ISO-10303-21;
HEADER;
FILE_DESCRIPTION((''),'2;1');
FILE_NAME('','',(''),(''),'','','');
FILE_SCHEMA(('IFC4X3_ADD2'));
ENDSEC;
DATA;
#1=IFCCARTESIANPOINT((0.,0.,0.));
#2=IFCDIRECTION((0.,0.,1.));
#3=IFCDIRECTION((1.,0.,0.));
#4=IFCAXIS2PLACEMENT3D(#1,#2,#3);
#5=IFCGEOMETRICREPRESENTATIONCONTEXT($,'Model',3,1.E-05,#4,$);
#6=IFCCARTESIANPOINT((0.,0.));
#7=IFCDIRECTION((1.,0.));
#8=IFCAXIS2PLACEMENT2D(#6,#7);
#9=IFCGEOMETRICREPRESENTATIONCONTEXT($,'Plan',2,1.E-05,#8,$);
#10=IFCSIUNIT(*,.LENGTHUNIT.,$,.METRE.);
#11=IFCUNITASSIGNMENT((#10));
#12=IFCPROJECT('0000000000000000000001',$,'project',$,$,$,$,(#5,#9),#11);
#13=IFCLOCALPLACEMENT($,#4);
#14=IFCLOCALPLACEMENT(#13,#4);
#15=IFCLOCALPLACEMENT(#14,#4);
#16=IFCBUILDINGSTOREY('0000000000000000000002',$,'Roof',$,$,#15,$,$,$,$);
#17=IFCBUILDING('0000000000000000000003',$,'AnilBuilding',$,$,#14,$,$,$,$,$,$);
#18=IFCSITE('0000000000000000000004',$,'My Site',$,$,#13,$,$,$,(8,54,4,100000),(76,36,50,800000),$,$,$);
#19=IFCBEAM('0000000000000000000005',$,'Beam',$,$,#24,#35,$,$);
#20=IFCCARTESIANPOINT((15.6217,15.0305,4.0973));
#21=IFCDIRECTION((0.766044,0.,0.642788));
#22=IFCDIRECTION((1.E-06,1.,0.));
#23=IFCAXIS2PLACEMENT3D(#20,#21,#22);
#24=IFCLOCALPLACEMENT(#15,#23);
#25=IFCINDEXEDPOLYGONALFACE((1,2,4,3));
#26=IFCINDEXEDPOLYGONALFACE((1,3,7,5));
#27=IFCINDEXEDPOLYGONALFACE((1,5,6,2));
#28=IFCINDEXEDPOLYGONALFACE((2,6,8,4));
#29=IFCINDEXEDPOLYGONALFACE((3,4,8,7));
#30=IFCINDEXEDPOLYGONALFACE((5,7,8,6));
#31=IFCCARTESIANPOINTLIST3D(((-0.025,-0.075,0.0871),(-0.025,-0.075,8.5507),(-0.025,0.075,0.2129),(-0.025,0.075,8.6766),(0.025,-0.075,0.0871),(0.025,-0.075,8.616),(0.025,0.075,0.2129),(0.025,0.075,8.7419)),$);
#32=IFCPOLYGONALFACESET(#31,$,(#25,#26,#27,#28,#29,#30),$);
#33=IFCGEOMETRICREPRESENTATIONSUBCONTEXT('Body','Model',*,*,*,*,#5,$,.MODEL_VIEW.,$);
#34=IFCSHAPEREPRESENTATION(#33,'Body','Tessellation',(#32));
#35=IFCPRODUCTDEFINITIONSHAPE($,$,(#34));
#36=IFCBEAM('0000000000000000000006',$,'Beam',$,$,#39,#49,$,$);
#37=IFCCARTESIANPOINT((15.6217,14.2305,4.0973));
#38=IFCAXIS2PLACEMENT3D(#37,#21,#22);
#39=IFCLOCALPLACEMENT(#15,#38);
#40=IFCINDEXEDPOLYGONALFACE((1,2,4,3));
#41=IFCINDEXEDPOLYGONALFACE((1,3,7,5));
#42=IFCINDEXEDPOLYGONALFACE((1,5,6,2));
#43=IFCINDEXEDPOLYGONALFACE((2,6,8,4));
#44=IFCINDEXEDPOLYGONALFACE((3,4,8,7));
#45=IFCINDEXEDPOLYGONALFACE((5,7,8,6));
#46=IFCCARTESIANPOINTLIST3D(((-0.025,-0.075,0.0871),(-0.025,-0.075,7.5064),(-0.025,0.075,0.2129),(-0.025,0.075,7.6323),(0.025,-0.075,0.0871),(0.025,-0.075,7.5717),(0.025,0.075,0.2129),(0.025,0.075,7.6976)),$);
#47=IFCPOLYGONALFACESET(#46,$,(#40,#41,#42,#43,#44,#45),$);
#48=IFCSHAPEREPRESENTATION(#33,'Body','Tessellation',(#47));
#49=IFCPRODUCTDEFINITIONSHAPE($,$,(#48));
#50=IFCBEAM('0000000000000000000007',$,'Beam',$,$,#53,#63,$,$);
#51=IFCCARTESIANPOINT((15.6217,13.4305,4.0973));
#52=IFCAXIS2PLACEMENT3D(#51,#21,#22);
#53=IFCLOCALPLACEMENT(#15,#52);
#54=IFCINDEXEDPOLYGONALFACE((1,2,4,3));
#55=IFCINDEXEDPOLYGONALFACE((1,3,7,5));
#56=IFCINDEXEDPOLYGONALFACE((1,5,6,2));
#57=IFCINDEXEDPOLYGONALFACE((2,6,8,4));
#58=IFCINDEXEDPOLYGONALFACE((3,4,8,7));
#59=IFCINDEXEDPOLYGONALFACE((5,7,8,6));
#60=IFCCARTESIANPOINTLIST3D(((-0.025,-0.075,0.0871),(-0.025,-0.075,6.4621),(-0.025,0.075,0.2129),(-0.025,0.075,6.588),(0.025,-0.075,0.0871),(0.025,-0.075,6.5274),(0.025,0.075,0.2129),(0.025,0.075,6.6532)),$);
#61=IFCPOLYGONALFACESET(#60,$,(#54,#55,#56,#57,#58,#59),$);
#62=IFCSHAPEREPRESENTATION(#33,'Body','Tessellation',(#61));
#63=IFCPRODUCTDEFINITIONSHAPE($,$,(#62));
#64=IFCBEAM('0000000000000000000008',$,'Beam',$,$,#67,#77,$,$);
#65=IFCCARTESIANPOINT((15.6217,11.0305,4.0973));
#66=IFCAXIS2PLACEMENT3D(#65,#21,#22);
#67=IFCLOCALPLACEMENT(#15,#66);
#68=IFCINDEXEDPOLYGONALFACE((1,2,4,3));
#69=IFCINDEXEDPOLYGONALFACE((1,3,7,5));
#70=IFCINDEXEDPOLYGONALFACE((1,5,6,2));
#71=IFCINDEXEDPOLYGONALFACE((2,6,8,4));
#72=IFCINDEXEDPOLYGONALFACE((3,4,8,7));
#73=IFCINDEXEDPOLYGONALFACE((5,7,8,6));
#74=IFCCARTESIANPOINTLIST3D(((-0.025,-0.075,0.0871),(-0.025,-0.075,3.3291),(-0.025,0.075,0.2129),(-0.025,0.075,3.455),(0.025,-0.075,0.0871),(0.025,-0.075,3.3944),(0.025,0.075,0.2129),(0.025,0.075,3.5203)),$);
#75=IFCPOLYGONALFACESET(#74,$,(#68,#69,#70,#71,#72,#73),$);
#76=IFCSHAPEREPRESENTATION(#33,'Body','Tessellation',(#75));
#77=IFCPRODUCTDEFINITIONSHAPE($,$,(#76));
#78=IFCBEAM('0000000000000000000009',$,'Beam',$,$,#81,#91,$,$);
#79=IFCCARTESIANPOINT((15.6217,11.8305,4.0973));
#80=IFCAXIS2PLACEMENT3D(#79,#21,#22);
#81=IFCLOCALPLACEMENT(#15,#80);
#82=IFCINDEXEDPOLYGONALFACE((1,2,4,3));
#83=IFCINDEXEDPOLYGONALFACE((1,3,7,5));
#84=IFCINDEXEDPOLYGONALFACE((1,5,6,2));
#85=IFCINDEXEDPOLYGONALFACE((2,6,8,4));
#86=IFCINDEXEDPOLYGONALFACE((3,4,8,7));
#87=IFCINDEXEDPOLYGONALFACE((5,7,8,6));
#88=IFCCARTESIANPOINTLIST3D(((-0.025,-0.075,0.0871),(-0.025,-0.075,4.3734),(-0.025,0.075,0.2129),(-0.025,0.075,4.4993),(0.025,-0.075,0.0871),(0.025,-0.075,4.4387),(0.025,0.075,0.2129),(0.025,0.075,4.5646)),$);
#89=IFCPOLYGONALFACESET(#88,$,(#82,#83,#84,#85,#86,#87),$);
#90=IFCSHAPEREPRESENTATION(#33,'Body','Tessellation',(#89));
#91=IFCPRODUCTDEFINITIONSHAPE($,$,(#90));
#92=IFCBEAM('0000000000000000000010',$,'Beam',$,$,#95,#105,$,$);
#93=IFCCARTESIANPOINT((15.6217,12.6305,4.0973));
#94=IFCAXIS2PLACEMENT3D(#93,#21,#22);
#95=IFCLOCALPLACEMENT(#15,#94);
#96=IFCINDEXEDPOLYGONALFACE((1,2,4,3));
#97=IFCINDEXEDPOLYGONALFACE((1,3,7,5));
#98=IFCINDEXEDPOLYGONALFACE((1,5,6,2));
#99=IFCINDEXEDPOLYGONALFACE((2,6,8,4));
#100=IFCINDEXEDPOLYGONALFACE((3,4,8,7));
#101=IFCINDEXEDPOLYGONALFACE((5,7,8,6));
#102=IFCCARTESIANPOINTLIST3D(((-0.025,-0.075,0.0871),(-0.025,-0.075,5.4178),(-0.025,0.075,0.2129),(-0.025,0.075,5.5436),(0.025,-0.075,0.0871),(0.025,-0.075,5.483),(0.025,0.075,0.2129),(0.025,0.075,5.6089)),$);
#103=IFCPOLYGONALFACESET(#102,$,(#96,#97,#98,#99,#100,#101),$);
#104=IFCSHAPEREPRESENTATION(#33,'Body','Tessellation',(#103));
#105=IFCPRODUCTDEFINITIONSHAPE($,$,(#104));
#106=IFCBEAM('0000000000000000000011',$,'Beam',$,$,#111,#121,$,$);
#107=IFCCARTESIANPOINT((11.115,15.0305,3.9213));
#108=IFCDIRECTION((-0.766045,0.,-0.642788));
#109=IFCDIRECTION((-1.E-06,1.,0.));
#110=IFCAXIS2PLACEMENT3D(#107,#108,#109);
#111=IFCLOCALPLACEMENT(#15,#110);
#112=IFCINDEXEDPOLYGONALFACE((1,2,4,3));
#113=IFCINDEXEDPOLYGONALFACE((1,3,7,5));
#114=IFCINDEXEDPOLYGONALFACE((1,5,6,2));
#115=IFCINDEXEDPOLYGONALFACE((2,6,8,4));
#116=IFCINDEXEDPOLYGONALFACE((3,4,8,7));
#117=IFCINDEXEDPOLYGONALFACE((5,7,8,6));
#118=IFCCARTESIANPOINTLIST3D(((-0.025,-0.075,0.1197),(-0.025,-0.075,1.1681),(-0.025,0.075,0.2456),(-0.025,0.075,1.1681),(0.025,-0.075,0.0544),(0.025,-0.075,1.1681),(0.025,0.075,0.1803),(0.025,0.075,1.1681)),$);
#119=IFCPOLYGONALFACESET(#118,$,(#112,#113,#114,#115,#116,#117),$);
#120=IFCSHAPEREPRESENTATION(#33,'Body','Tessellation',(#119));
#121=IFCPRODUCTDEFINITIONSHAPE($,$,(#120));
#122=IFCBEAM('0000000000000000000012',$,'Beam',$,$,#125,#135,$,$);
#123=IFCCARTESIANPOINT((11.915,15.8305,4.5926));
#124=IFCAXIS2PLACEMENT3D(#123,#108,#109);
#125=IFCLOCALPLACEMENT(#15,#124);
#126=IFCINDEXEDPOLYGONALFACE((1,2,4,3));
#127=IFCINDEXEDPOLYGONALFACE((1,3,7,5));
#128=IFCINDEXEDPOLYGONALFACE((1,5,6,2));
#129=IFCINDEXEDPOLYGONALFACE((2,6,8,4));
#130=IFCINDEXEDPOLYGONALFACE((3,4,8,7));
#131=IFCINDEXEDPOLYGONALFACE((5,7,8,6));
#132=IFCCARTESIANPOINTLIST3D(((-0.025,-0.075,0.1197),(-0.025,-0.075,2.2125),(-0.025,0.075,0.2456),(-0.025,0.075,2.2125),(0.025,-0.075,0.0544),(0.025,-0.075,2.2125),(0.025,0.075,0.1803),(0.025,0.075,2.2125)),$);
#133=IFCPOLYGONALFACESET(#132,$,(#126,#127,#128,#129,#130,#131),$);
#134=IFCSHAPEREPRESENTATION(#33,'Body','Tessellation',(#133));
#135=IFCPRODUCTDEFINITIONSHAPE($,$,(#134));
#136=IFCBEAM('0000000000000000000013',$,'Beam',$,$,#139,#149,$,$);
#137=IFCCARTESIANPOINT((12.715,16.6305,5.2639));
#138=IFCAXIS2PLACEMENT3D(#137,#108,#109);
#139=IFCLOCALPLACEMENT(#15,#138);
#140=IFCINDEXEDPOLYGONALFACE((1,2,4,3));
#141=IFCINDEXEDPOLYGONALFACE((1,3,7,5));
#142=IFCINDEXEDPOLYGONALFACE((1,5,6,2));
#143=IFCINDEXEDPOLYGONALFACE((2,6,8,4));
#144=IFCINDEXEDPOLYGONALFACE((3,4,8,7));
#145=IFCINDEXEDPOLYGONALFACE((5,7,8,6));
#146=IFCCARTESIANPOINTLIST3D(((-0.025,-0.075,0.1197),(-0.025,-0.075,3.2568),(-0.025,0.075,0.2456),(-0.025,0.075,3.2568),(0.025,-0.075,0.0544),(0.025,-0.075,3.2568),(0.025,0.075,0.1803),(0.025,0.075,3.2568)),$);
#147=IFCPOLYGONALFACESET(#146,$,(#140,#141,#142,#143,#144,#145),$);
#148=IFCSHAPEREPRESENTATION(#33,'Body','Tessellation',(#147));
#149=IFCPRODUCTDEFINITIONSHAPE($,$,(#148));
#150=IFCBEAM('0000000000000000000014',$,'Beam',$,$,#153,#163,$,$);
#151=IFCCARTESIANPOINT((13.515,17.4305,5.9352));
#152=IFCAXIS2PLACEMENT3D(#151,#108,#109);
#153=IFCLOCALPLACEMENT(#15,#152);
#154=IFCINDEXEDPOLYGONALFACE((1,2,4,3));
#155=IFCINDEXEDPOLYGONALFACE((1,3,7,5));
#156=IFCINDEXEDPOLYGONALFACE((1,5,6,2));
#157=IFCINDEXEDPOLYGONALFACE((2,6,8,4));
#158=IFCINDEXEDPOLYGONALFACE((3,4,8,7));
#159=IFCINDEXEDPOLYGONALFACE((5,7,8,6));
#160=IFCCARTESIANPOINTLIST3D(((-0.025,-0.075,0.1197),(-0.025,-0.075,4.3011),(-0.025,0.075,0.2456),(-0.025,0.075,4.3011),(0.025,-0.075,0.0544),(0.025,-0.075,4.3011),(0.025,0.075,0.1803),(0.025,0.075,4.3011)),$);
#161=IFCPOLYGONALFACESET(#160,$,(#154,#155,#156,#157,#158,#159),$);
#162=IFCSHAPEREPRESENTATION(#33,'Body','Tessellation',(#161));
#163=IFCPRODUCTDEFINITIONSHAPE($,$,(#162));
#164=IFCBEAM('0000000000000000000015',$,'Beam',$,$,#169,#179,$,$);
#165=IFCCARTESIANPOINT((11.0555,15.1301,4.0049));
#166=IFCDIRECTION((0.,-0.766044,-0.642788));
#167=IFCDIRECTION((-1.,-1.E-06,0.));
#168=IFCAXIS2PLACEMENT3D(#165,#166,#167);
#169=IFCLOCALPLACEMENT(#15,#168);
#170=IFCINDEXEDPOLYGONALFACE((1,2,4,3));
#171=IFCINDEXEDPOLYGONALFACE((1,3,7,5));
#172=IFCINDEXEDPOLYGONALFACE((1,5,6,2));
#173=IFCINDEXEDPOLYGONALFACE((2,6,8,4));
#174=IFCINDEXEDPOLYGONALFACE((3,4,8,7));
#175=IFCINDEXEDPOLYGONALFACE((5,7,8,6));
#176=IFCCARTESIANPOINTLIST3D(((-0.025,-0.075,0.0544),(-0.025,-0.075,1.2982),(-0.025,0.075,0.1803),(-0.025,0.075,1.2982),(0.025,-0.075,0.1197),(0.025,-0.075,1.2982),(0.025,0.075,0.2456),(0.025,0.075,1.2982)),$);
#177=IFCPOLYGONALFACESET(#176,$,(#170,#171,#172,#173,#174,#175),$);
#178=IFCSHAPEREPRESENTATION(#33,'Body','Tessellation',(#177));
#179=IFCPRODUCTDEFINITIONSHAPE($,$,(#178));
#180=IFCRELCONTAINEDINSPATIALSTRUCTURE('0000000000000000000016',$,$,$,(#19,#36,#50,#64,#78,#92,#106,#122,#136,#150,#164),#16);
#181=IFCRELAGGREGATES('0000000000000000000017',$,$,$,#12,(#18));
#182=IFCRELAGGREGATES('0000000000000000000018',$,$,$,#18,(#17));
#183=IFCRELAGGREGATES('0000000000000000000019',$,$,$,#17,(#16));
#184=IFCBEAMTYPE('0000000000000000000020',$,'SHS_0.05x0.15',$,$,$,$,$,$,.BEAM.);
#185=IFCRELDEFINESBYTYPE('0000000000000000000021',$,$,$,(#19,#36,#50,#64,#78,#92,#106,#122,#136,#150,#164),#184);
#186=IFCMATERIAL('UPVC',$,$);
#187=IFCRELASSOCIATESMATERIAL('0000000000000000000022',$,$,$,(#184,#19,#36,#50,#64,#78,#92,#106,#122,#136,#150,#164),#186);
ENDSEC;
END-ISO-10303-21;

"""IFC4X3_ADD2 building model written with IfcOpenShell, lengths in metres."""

from ifc_helpers import new_model, si_unit, frame, origin_with_axes, origin_2d_with_axis, place, context, subcontext, project, spatial, indexed_curve, outline, extrude, clip, halfspace, material, material_profile, profile_set, profile_usage, type_object, element, save


model = new_model("IFC4X3_ADD2")

# Units and contexts
model_context = context("Model", 3, precision=1e-05, world=origin_with_axes())
plan_context = context("Plan", 2, precision=1e-05, world=origin_2d_with_axis())
body_context_1 = subcontext(model_context, "Body", "Model", "MODEL_VIEW")
ifc_project = project(units=[si_unit("LENGTHUNIT", "METRE")], contexts=[model_context, plan_context])

# Site, building, storey
site_placement = place(None, origin_with_axes())
site = spatial("IfcSite", under=ifc_project, at=site_placement, Name="My Site", RefLatitude=(8, 54, 4, 100000), RefLongitude=(76, 36, 50, 800000))
building_placement = place(site_placement, origin_with_axes())
building = spatial("IfcBuilding", under=site, at=building_placement, Name="AnilBuilding")
storey_placement = place(building_placement, origin_with_axes())
storey = spatial("IfcBuildingStorey", under=building, at=storey_placement, Name="Roof")

# Shared definitions
ifc_material_1 = material(Name="UPVC")

# Beams
ifc_material_profile_1 = material_profile(ifc_material_1, outline(indexed_curve([(-0.025, 0.075), (0.025, 0.075), (0.025, -0.075), (-0.025, -0.075), (-0.025, 0.075)])))
ifc_profile_set_1 = profile_set([ifc_material_profile_1])
beam_type = type_object("IfcBeamType", Name="SHS_0.05x0.15", PredefinedType="BEAM", material=ifc_profile_set_1)
ifc_profile_usage_1 = profile_usage(ifc_profile_set_1, cardinal=5)
beam_1_placement = place(storey_placement, frame((15.6217, 15.0305, 4.0973), z_axis=(0.766044, 0.0, 0.642788), x_axis=(0.000001, 1.0, 0.0)))
element("IfcBeam", 1, at=beam_1_placement, inside=storey, type_object=beam_type, material=ifc_profile_usage_1, Name="Beam", context=body_context_1, shape_type="Clipping", body=[
    clip(clip(extrude(outline(indexed_curve([(-0.025, 0.075), (0.025, 0.075), (0.025, -0.075), (-0.025, -0.075), (-0.025, 0.075)])), origin_with_axes(), (0.0, 0.0, 1.0), 8.7963), halfspace(frame((-6.5003, -0.0316, 0.1235), z_axis=(0.0, 0.642788, -0.766044), x_axis=(1.0, 0.0, 0.0)), False)), halfspace(frame((0.7644, -0.0275, 9.6211), z_axis=(-0.707106, -0.45452, 0.541676), x_axis=(-0.540717, 0.841205, 0.0)), False)),
])
ifc_profile_usage_2 = profile_usage(ifc_profile_set_1, cardinal=5)
beam_2_placement = place(storey_placement, frame((15.6217, 14.2305, 4.0973), z_axis=(0.766044, 0.0, 0.642788), x_axis=(0.000001, 1.0, 0.0)))
element("IfcBeam", 2, at=beam_2_placement, inside=storey, type_object=beam_type, material=ifc_profile_usage_2, Name="Beam", context=body_context_1, shape_type="Clipping", body=[
    clip(clip(extrude(outline(indexed_curve([(-0.025, 0.075), (0.025, 0.075), (0.025, -0.075), (-0.025, -0.075), (-0.025, 0.075)])), origin_with_axes(), (0.0, 0.0, 1.0), 7.752), halfspace(frame((-5.7003, -0.0316, 0.1235), z_axis=(0.0, 0.642788, -0.766044), x_axis=(1.0, 0.0, 0.0)), False)), halfspace(frame((1.5644, -0.0275, 9.6211), z_axis=(-0.707106, -0.45452, 0.541676), x_axis=(-0.540717, 0.841205, 0.0)), False)),
])
ifc_profile_usage_3 = profile_usage(ifc_profile_set_1, cardinal=5)
beam_3_placement = place(storey_placement, frame((15.6217, 13.4305, 4.0973), z_axis=(0.766044, 0.0, 0.642788), x_axis=(0.000001, 1.0, 0.0)))
element("IfcBeam", 3, at=beam_3_placement, inside=storey, type_object=beam_type, material=ifc_profile_usage_3, Name="Beam", context=body_context_1, shape_type="Clipping", body=[
    clip(clip(extrude(outline(indexed_curve([(-0.025, 0.075), (0.025, 0.075), (0.025, -0.075), (-0.025, -0.075), (-0.025, 0.075)])), origin_with_axes(), (0.0, 0.0, 1.0), 6.7077), halfspace(frame((-4.9003, -0.0316, 0.1235), z_axis=(0.0, 0.642788, -0.766044), x_axis=(1.0, 0.0, 0.0)), False)), halfspace(frame((2.3644, -0.0275, 9.6211), z_axis=(-0.707106, -0.45452, 0.541676), x_axis=(-0.540717, 0.841205, 0.0)), False)),
])
ifc_profile_usage_4 = profile_usage(ifc_profile_set_1, cardinal=5)
beam_4_placement = place(storey_placement, frame((15.6217, 11.0305, 4.0973), z_axis=(0.766044, 0.0, 0.642788), x_axis=(0.000001, 1.0, 0.0)))
element("IfcBeam", 4, at=beam_4_placement, inside=storey, type_object=beam_type, material=ifc_profile_usage_4, Name="Beam", context=body_context_1, shape_type="Clipping", body=[
    clip(clip(extrude(outline(indexed_curve([(-0.025, 0.075), (0.025, 0.075), (0.025, -0.075), (-0.025, -0.075), (-0.025, 0.075)])), origin_with_axes(), (0.0, 0.0, 1.0), 3.5747), halfspace(frame((-2.5003, -0.0316, 0.1235), z_axis=(0.0, 0.642788, -0.766044), x_axis=(1.0, 0.0, 0.0)), False)), halfspace(frame((4.7644, -0.0275, 9.6211), z_axis=(-0.707106, -0.45452, 0.541676), x_axis=(-0.540717, 0.841205, 0.0)), False)),
])
ifc_profile_usage_5 = profile_usage(ifc_profile_set_1, cardinal=5)
beam_5_placement = place(storey_placement, frame((15.6217, 11.8305, 4.0973), z_axis=(0.766044, 0.0, 0.642788), x_axis=(0.000001, 1.0, 0.0)))
element("IfcBeam", 5, at=beam_5_placement, inside=storey, type_object=beam_type, material=ifc_profile_usage_5, Name="Beam", context=body_context_1, shape_type="Clipping", body=[
    clip(clip(extrude(outline(indexed_curve([(-0.025, 0.075), (0.025, 0.075), (0.025, -0.075), (-0.025, -0.075), (-0.025, 0.075)])), origin_with_axes(), (0.0, 0.0, 1.0), 4.619), halfspace(frame((-3.3003, -0.0316, 0.1235), z_axis=(0.0, 0.642788, -0.766044), x_axis=(1.0, 0.0, 0.0)), False)), halfspace(frame((3.9644, -0.0275, 9.6211), z_axis=(-0.707106, -0.45452, 0.541676), x_axis=(-0.540717, 0.841205, 0.0)), False)),
])
ifc_profile_usage_6 = profile_usage(ifc_profile_set_1, cardinal=5)
beam_6_placement = place(storey_placement, frame((15.6217, 12.6305, 4.0973), z_axis=(0.766044, 0.0, 0.642788), x_axis=(0.000001, 1.0, 0.0)))
element("IfcBeam", 6, at=beam_6_placement, inside=storey, type_object=beam_type, material=ifc_profile_usage_6, Name="Beam", context=body_context_1, shape_type="Clipping", body=[
    clip(clip(extrude(outline(indexed_curve([(-0.025, 0.075), (0.025, 0.075), (0.025, -0.075), (-0.025, -0.075), (-0.025, 0.075)])), origin_with_axes(), (0.0, 0.0, 1.0), 5.6633), halfspace(frame((-4.1003, -0.0316, 0.1235), z_axis=(0.0, 0.642788, -0.766044), x_axis=(1.0, 0.0, 0.0)), False)), halfspace(frame((3.1644, -0.0275, 9.6211), z_axis=(-0.707106, -0.45452, 0.541676), x_axis=(-0.540717, 0.841205, 0.0)), False)),
])
ifc_profile_usage_7 = profile_usage(ifc_profile_set_1, cardinal=5)
beam_7_placement = place(storey_placement, frame((11.115, 15.0305, 3.9213), z_axis=(-0.766045, 0.0, -0.642788), x_axis=(-0.000001, 1.0, 0.0)))
element("IfcBeam", 7, at=beam_7_placement, inside=storey, type_object=beam_type, material=ifc_profile_usage_7, Name="Beam", context=body_context_1, shape_type="Clipping", body=[
    clip(extrude(outline(indexed_curve([(-0.025, 0.075), (0.025, 0.075), (0.025, -0.075), (-0.025, -0.075), (-0.025, 0.075)])), origin_with_axes(), (0.0, 0.0, 1.0), 1.1681), halfspace(frame((3.0111, -0.0072, -3.7868), z_axis=(-0.707107, 0.454519, -0.541675), x_axis=(0.540716, 0.841205, 0.0)), False)),
])
ifc_profile_usage_8 = profile_usage(ifc_profile_set_1, cardinal=5)
beam_8_placement = place(storey_placement, frame((11.915, 15.8305, 4.5926), z_axis=(-0.766045, 0.0, -0.642788), x_axis=(-0.000001, 1.0, 0.0)))
element("IfcBeam", 8, at=beam_8_placement, inside=storey, type_object=beam_type, material=ifc_profile_usage_8, Name="Beam", context=body_context_1, shape_type="Clipping", body=[
    clip(extrude(outline(indexed_curve([(-0.025, 0.075), (0.025, 0.075), (0.025, -0.075), (-0.025, -0.075), (-0.025, 0.075)])), origin_with_axes(), (0.0, 0.0, 1.0), 2.2125), halfspace(frame((2.2111, -0.0072, -2.7425), z_axis=(-0.707107, 0.454519, -0.541675), x_axis=(0.540716, 0.841205, 0.0)), False)),
])
ifc_profile_usage_9 = profile_usage(ifc_profile_set_1, cardinal=5)
beam_9_placement = place(storey_placement, frame((12.715, 16.6305, 5.2639), z_axis=(-0.766045, 0.0, -0.642788), x_axis=(-0.000001, 1.0, 0.0)))
element("IfcBeam", 9, at=beam_9_placement, inside=storey, type_object=beam_type, material=ifc_profile_usage_9, Name="Beam", context=body_context_1, shape_type="Clipping", body=[
    clip(extrude(outline(indexed_curve([(-0.025, 0.075), (0.025, 0.075), (0.025, -0.075), (-0.025, -0.075), (-0.025, 0.075)])), origin_with_axes(), (0.0, 0.0, 1.0), 3.2568), halfspace(frame((1.4111, -0.0072, -1.6981), z_axis=(-0.707107, 0.454519, -0.541675), x_axis=(0.540716, 0.841205, 0.0)), False)),
])
ifc_profile_usage_10 = profile_usage(ifc_profile_set_1, cardinal=5)
beam_10_placement = place(storey_placement, frame((13.515, 17.4305, 5.9352), z_axis=(-0.766045, 0.0, -0.642788), x_axis=(-0.000001, 1.0, 0.0)))
element("IfcBeam", 10, at=beam_10_placement, inside=storey, type_object=beam_type, material=ifc_profile_usage_10, Name="Beam", context=body_context_1, shape_type="Clipping", body=[
    clip(extrude(outline(indexed_curve([(-0.025, 0.075), (0.025, 0.075), (0.025, -0.075), (-0.025, -0.075), (-0.025, 0.075)])), origin_with_axes(), (0.0, 0.0, 1.0), 4.3011), halfspace(frame((0.6111, -0.0072, -0.6538), z_axis=(-0.707107, 0.454519, -0.541675), x_axis=(0.540716, 0.841205, 0.0)), False)),
])
ifc_profile_usage_11 = profile_usage(ifc_profile_set_1, cardinal=5)
beam_11_placement = place(storey_placement, frame((11.0555, 15.1301, 4.0049), z_axis=(0.0, -0.766044, -0.642788), x_axis=(-1.0, -0.000001, 0.0)))
element("IfcBeam", 11, at=beam_11_placement, inside=storey, type_object=beam_type, material=ifc_profile_usage_11, Name="Beam", context=body_context_1, shape_type="Clipping", body=[
    clip(extrude(outline(indexed_curve([(-0.025, 0.075), (0.025, 0.075), (0.025, -0.075), (-0.025, -0.075), (-0.025, 0.075)])), origin_with_axes(), (0.0, 0.0, 1.0), 1.2982), halfspace(frame((-2.991, 0.0439, -3.7177), z_axis=(0.707107, 0.454519, -0.541675), x_axis=(0.540716, -0.841205, 0.0)), False)),
])

save(model, "model.ifc")
